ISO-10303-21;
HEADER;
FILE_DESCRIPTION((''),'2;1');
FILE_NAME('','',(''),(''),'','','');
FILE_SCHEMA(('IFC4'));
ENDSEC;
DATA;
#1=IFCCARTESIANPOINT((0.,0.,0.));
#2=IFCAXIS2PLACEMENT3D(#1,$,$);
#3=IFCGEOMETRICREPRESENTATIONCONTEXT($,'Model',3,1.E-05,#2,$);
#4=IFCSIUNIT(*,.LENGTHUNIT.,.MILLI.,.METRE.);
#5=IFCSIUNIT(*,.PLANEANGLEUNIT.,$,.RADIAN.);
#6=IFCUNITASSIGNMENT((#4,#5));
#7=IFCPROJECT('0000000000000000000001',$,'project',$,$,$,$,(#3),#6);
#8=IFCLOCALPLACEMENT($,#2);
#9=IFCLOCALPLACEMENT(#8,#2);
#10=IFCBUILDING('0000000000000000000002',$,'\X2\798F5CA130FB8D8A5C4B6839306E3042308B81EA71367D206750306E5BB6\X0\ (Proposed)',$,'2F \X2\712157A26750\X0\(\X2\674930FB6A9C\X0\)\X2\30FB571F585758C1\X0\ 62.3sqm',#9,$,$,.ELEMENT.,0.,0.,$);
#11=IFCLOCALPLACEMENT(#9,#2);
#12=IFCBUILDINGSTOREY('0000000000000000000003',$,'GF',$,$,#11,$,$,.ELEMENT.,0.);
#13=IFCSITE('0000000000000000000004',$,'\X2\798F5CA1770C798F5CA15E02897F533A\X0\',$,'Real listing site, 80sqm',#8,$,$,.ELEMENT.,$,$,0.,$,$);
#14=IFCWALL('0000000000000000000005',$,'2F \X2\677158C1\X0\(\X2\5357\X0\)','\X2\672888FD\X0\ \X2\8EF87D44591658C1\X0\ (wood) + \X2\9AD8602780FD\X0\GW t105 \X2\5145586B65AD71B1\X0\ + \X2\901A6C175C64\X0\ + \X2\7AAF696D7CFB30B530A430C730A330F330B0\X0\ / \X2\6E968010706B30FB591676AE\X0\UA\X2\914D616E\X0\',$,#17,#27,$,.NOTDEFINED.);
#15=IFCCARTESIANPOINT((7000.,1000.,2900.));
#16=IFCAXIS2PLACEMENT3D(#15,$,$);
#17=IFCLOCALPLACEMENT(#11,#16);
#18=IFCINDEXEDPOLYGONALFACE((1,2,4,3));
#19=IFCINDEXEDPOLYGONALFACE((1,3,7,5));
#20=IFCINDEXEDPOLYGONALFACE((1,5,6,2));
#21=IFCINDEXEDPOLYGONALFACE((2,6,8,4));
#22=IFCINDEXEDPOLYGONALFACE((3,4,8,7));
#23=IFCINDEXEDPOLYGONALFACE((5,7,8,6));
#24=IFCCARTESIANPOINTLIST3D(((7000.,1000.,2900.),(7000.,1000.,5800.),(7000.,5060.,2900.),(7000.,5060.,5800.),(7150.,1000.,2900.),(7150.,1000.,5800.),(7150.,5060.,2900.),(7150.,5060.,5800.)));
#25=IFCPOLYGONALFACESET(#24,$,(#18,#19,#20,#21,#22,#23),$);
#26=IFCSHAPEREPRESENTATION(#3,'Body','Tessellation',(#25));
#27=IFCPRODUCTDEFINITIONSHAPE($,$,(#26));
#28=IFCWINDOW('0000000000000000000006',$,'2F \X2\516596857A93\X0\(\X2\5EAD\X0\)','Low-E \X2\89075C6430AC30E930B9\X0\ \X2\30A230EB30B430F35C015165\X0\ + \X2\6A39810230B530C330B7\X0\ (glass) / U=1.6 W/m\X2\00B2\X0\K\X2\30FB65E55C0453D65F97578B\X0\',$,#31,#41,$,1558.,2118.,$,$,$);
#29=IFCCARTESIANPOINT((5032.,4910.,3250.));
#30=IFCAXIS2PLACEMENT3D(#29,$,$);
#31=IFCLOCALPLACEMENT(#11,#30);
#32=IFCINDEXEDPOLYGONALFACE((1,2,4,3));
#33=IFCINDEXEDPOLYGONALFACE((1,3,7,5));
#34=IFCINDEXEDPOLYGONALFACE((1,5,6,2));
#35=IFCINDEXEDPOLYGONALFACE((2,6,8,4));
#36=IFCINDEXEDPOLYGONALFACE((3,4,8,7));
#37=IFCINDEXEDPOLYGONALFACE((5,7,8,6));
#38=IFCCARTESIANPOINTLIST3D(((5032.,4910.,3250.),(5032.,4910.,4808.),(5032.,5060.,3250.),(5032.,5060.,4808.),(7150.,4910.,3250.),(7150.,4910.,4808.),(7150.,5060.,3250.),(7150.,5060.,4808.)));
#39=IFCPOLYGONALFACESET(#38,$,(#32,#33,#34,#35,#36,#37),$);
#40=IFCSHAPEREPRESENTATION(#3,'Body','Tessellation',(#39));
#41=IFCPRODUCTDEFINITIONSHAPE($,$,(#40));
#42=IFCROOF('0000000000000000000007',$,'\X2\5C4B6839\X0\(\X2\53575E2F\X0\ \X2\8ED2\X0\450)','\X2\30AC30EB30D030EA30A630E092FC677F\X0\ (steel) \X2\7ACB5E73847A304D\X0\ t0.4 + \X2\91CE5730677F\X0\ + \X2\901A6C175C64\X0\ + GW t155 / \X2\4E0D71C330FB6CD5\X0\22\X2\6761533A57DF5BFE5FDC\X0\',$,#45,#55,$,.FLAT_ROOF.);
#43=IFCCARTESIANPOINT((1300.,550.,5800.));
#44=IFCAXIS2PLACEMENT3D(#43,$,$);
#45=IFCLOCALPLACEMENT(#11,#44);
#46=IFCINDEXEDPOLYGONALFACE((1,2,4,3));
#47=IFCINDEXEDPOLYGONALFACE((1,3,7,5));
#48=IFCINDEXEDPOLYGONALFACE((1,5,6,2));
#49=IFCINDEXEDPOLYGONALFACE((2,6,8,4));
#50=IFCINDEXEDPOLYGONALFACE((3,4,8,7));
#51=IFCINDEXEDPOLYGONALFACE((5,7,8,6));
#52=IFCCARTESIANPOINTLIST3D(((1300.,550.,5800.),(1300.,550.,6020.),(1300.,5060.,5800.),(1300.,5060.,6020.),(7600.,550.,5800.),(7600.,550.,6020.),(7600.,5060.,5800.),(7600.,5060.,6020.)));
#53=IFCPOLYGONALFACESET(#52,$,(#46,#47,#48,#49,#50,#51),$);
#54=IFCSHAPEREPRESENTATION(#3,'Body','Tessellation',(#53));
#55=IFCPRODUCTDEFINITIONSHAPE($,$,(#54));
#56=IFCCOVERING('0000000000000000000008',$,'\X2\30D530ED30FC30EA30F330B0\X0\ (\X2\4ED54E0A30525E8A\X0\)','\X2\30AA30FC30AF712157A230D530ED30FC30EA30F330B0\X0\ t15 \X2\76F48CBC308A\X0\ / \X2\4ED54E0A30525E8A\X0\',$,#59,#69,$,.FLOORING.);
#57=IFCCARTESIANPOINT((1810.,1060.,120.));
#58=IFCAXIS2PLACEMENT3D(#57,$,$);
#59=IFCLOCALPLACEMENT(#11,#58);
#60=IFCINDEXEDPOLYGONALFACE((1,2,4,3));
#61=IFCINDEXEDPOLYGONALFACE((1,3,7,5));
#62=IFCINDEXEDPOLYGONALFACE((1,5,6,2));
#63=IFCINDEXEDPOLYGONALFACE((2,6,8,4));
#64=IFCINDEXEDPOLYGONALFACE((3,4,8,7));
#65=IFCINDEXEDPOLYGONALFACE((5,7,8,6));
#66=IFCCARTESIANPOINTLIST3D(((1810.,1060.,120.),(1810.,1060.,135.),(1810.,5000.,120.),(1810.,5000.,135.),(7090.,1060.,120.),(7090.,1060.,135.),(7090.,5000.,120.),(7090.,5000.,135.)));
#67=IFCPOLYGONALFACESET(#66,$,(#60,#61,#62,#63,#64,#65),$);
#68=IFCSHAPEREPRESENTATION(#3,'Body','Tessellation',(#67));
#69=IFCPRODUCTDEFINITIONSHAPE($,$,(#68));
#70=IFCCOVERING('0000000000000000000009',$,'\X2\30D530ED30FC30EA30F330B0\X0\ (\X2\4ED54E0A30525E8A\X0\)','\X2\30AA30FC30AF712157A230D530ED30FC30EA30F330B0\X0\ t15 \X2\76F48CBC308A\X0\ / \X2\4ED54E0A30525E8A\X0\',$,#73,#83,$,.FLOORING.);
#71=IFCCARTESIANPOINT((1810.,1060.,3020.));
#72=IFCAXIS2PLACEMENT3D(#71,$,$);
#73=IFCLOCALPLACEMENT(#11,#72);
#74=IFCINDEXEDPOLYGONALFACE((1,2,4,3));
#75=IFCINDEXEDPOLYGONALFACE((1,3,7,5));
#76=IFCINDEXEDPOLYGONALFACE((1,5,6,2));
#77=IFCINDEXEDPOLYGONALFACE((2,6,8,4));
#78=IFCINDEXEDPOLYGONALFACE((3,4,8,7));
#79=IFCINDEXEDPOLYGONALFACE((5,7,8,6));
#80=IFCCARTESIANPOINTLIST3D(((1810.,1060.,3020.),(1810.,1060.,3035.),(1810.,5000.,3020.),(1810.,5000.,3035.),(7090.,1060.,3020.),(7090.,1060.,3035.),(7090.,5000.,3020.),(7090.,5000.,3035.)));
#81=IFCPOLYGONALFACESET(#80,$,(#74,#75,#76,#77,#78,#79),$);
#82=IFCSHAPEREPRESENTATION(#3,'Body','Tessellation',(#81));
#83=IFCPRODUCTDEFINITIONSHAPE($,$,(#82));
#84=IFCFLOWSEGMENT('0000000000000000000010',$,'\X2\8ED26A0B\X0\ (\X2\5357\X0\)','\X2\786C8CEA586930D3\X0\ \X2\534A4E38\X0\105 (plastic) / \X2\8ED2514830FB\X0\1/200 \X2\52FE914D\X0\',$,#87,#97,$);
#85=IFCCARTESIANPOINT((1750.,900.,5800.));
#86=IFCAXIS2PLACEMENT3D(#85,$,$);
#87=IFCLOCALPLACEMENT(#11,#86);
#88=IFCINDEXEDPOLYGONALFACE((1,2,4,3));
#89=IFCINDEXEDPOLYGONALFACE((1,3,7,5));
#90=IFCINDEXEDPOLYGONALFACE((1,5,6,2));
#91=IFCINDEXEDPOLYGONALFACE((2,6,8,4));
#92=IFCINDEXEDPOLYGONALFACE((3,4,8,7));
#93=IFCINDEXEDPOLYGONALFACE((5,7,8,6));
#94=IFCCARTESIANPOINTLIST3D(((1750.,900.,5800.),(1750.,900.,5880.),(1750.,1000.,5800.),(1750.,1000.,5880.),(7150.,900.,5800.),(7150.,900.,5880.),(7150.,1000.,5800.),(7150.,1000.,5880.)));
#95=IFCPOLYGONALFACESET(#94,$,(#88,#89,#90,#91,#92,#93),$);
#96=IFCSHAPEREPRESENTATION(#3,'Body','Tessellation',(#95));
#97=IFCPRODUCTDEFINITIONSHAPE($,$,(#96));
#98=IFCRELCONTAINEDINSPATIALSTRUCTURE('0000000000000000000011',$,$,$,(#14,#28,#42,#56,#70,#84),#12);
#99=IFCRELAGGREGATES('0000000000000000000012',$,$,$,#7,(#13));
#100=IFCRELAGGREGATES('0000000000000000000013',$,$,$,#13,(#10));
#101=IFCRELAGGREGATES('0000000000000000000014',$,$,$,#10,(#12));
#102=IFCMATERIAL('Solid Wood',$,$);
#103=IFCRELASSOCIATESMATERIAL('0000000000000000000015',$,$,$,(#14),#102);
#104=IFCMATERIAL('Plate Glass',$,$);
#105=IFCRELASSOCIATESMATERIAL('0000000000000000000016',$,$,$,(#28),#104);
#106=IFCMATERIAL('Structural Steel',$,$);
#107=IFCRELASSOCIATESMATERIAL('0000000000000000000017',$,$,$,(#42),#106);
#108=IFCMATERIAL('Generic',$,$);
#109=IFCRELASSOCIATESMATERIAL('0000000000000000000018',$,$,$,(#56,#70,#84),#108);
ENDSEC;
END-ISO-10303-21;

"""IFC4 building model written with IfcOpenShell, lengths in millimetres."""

from ifc_helpers import new_model, si_unit, frame, frame_2d, origin, place, context, project, spatial, rectangle, extrude, material, element, fill, save


model = new_model("IFC4")

# Units and contexts
model_context = context("Model", 3, precision=1e-05, world=origin())
ifc_project = project(units=[si_unit("LENGTHUNIT", "METRE", prefix="MILLI"), si_unit("PLANEANGLEUNIT", "RADIAN")], contexts=[model_context])

# Site, building, storey
site_placement = place(None, origin())
site = spatial("IfcSite", under=ifc_project, at=site_placement, Name="福岡県福岡市西区", ObjectType="Real listing site, 80sqm", CompositionType="ELEMENT", RefElevation=0.0)
building_placement = place(site_placement, origin())
building = spatial("IfcBuilding", under=site, at=building_placement, Name="福岡・越屋根のある自然素材の家 (Proposed)", ObjectType="2F 無垢材(杉・檜)・土塗壁 62.3sqm", CompositionType="ELEMENT", ElevationOfRefHeight=0.0, ElevationOfTerrain=0.0)
storey_placement = place(building_placement, origin())
storey = spatial("IfcBuildingStorey", under=building, at=storey_placement, Name="GF", CompositionType="ELEMENT", Elevation=0.0)

# Shared definitions
ifc_material_1 = material(Name="Solid Wood")

# Wall, opening, window
ifc_material_2 = material(Name="Plate Glass")
wall_1_placement = place(storey_placement, frame((7000.0, 1000.0, 2900.0)))
wall_1 = element("IfcWall", 1, at=wall_1_placement, inside=storey, material=ifc_material_1, Name="2F 東壁(南)", Description="木製 軸組外壁 (wood) + 高性能GW t105 充填断熱 + 通気層 + 窯業系サイディング / 準耐火・外皮UA配慮", PredefinedType="NOTDEFINED", context=model_context, shape_type="SweptSolid", body=[
    extrude(rectangle(XDim=150.0, YDim=4060.0, at=frame_2d((75.0, 2030.0))), frame((7000.0, 1000.0, 2900.0)), (0.0, 0.0, 1.0), 2900.0),
])
opening_1_placement = place(storey_placement, frame((5032.0, 4910.0, 3250.0)))
opening_1 = element("IfcOpeningElement", 2, at=opening_1_placement, cuts=wall_1, PredefinedType="NOTDEFINED", context=model_context, shape_type="SweptSolid", body=[
    extrude(rectangle(XDim=2118.0, YDim=150.0, at=frame_2d((1059.0, 75.0))), frame((5032.0, 4910.0, 3250.0)), (0.0, 0.0, 1.0), 1558.0),
])
window_1_placement = place(storey_placement, frame((5032.0, 4910.0, 3250.0)))
window_1 = element("IfcWindow", 3, at=window_1_placement, inside=storey, material=ifc_material_2, Name="2F 入隅窓(庭)", Description="Low-E 複層ガラス アルゴン封入 + 樹脂サッシ (glass) / U=1.6 W/m²K・日射取得型", OverallHeight=1558.0, OverallWidth=2118.0, context=model_context, shape_type="SweptSolid", body=[
    extrude(rectangle(XDim=2118.0, YDim=150.0, at=frame_2d((1059.0, 75.0))), frame((5032.0, 4910.0, 3250.0)), (0.0, 0.0, 1.0), 1558.0),
])
fill(opening_1, window_1)

# Roof
ifc_material_3 = material(Name="Structural Steel")
for number, where, name in (
    (4, (1300.0, 550.0, 5800.0), "屋根(南帯 軒450)"),
):
    element("IfcRoof", number, at=place(storey_placement, frame(where)), inside=storey, material=ifc_material_3, Name=name, Description="ガルバリウム鋼板 (steel) 立平葺き t0.4 + 野地板 + 通気層 + GW t155 / 不燃・法22条区域対応", PredefinedType="FLAT_ROOF", context=model_context, shape_type="SweptSolid", body=[
        extrude(rectangle(XDim=6300.0, YDim=4510.0, at=frame_2d((3150.0, 2255.0))), frame((1300.0, 550.0, 5800.0)), (0.0, 0.0, 1.0), 220.0),
    ])

# Coverings
ifc_material_4 = material(Name="Generic")
covering_1_placement = place(storey_placement, frame((1810.0, 1060.0, 120.0)))
element("IfcCovering", 5, at=covering_1_placement, inside=storey, material=ifc_material_4, Name="フローリング (仕上げ床)", Description="オーク無垢フローリング t15 直貼り / 仕上げ床", PredefinedType="FLOORING", context=model_context, shape_type="SweptSolid", body=[
    extrude(rectangle(XDim=5280.0, YDim=3940.0, at=frame_2d((2640.0, 1970.0))), frame((1810.0, 1060.0, 120.0)), (0.0, 0.0, 1.0), 15.0),
])
covering_2_placement = place(storey_placement, frame((1810.0, 1060.0, 3020.0)))
element("IfcCovering", 6, at=covering_2_placement, inside=storey, material=ifc_material_4, Name="フローリング (仕上げ床)", Description="オーク無垢フローリング t15 直貼り / 仕上げ床", PredefinedType="FLOORING", context=model_context, shape_type="SweptSolid", body=[
    extrude(rectangle(XDim=5280.0, YDim=3940.0, at=frame_2d((2640.0, 1970.0))), frame((1810.0, 1060.0, 3020.0)), (0.0, 0.0, 1.0), 15.0),
])

# Flow segment
flow_segment_placement = place(storey_placement, frame((1750.0, 900.0, 5800.0)))
element("IfcFlowSegment", 7, at=flow_segment_placement, inside=storey, material=ifc_material_4, Name="軒樋 (南)", Description="硬質塩ビ 半丸105 (plastic) / 軒先・1/200 勾配", context=model_context, shape_type="SweptSolid", body=[
    extrude(rectangle(XDim=5400.0, YDim=100.0, at=frame_2d((2700.0, 50.0))), frame((1750.0, 900.0, 5800.0)), (0.0, 0.0, 1.0), 80.0),
])

save(model, "model.ifc")
